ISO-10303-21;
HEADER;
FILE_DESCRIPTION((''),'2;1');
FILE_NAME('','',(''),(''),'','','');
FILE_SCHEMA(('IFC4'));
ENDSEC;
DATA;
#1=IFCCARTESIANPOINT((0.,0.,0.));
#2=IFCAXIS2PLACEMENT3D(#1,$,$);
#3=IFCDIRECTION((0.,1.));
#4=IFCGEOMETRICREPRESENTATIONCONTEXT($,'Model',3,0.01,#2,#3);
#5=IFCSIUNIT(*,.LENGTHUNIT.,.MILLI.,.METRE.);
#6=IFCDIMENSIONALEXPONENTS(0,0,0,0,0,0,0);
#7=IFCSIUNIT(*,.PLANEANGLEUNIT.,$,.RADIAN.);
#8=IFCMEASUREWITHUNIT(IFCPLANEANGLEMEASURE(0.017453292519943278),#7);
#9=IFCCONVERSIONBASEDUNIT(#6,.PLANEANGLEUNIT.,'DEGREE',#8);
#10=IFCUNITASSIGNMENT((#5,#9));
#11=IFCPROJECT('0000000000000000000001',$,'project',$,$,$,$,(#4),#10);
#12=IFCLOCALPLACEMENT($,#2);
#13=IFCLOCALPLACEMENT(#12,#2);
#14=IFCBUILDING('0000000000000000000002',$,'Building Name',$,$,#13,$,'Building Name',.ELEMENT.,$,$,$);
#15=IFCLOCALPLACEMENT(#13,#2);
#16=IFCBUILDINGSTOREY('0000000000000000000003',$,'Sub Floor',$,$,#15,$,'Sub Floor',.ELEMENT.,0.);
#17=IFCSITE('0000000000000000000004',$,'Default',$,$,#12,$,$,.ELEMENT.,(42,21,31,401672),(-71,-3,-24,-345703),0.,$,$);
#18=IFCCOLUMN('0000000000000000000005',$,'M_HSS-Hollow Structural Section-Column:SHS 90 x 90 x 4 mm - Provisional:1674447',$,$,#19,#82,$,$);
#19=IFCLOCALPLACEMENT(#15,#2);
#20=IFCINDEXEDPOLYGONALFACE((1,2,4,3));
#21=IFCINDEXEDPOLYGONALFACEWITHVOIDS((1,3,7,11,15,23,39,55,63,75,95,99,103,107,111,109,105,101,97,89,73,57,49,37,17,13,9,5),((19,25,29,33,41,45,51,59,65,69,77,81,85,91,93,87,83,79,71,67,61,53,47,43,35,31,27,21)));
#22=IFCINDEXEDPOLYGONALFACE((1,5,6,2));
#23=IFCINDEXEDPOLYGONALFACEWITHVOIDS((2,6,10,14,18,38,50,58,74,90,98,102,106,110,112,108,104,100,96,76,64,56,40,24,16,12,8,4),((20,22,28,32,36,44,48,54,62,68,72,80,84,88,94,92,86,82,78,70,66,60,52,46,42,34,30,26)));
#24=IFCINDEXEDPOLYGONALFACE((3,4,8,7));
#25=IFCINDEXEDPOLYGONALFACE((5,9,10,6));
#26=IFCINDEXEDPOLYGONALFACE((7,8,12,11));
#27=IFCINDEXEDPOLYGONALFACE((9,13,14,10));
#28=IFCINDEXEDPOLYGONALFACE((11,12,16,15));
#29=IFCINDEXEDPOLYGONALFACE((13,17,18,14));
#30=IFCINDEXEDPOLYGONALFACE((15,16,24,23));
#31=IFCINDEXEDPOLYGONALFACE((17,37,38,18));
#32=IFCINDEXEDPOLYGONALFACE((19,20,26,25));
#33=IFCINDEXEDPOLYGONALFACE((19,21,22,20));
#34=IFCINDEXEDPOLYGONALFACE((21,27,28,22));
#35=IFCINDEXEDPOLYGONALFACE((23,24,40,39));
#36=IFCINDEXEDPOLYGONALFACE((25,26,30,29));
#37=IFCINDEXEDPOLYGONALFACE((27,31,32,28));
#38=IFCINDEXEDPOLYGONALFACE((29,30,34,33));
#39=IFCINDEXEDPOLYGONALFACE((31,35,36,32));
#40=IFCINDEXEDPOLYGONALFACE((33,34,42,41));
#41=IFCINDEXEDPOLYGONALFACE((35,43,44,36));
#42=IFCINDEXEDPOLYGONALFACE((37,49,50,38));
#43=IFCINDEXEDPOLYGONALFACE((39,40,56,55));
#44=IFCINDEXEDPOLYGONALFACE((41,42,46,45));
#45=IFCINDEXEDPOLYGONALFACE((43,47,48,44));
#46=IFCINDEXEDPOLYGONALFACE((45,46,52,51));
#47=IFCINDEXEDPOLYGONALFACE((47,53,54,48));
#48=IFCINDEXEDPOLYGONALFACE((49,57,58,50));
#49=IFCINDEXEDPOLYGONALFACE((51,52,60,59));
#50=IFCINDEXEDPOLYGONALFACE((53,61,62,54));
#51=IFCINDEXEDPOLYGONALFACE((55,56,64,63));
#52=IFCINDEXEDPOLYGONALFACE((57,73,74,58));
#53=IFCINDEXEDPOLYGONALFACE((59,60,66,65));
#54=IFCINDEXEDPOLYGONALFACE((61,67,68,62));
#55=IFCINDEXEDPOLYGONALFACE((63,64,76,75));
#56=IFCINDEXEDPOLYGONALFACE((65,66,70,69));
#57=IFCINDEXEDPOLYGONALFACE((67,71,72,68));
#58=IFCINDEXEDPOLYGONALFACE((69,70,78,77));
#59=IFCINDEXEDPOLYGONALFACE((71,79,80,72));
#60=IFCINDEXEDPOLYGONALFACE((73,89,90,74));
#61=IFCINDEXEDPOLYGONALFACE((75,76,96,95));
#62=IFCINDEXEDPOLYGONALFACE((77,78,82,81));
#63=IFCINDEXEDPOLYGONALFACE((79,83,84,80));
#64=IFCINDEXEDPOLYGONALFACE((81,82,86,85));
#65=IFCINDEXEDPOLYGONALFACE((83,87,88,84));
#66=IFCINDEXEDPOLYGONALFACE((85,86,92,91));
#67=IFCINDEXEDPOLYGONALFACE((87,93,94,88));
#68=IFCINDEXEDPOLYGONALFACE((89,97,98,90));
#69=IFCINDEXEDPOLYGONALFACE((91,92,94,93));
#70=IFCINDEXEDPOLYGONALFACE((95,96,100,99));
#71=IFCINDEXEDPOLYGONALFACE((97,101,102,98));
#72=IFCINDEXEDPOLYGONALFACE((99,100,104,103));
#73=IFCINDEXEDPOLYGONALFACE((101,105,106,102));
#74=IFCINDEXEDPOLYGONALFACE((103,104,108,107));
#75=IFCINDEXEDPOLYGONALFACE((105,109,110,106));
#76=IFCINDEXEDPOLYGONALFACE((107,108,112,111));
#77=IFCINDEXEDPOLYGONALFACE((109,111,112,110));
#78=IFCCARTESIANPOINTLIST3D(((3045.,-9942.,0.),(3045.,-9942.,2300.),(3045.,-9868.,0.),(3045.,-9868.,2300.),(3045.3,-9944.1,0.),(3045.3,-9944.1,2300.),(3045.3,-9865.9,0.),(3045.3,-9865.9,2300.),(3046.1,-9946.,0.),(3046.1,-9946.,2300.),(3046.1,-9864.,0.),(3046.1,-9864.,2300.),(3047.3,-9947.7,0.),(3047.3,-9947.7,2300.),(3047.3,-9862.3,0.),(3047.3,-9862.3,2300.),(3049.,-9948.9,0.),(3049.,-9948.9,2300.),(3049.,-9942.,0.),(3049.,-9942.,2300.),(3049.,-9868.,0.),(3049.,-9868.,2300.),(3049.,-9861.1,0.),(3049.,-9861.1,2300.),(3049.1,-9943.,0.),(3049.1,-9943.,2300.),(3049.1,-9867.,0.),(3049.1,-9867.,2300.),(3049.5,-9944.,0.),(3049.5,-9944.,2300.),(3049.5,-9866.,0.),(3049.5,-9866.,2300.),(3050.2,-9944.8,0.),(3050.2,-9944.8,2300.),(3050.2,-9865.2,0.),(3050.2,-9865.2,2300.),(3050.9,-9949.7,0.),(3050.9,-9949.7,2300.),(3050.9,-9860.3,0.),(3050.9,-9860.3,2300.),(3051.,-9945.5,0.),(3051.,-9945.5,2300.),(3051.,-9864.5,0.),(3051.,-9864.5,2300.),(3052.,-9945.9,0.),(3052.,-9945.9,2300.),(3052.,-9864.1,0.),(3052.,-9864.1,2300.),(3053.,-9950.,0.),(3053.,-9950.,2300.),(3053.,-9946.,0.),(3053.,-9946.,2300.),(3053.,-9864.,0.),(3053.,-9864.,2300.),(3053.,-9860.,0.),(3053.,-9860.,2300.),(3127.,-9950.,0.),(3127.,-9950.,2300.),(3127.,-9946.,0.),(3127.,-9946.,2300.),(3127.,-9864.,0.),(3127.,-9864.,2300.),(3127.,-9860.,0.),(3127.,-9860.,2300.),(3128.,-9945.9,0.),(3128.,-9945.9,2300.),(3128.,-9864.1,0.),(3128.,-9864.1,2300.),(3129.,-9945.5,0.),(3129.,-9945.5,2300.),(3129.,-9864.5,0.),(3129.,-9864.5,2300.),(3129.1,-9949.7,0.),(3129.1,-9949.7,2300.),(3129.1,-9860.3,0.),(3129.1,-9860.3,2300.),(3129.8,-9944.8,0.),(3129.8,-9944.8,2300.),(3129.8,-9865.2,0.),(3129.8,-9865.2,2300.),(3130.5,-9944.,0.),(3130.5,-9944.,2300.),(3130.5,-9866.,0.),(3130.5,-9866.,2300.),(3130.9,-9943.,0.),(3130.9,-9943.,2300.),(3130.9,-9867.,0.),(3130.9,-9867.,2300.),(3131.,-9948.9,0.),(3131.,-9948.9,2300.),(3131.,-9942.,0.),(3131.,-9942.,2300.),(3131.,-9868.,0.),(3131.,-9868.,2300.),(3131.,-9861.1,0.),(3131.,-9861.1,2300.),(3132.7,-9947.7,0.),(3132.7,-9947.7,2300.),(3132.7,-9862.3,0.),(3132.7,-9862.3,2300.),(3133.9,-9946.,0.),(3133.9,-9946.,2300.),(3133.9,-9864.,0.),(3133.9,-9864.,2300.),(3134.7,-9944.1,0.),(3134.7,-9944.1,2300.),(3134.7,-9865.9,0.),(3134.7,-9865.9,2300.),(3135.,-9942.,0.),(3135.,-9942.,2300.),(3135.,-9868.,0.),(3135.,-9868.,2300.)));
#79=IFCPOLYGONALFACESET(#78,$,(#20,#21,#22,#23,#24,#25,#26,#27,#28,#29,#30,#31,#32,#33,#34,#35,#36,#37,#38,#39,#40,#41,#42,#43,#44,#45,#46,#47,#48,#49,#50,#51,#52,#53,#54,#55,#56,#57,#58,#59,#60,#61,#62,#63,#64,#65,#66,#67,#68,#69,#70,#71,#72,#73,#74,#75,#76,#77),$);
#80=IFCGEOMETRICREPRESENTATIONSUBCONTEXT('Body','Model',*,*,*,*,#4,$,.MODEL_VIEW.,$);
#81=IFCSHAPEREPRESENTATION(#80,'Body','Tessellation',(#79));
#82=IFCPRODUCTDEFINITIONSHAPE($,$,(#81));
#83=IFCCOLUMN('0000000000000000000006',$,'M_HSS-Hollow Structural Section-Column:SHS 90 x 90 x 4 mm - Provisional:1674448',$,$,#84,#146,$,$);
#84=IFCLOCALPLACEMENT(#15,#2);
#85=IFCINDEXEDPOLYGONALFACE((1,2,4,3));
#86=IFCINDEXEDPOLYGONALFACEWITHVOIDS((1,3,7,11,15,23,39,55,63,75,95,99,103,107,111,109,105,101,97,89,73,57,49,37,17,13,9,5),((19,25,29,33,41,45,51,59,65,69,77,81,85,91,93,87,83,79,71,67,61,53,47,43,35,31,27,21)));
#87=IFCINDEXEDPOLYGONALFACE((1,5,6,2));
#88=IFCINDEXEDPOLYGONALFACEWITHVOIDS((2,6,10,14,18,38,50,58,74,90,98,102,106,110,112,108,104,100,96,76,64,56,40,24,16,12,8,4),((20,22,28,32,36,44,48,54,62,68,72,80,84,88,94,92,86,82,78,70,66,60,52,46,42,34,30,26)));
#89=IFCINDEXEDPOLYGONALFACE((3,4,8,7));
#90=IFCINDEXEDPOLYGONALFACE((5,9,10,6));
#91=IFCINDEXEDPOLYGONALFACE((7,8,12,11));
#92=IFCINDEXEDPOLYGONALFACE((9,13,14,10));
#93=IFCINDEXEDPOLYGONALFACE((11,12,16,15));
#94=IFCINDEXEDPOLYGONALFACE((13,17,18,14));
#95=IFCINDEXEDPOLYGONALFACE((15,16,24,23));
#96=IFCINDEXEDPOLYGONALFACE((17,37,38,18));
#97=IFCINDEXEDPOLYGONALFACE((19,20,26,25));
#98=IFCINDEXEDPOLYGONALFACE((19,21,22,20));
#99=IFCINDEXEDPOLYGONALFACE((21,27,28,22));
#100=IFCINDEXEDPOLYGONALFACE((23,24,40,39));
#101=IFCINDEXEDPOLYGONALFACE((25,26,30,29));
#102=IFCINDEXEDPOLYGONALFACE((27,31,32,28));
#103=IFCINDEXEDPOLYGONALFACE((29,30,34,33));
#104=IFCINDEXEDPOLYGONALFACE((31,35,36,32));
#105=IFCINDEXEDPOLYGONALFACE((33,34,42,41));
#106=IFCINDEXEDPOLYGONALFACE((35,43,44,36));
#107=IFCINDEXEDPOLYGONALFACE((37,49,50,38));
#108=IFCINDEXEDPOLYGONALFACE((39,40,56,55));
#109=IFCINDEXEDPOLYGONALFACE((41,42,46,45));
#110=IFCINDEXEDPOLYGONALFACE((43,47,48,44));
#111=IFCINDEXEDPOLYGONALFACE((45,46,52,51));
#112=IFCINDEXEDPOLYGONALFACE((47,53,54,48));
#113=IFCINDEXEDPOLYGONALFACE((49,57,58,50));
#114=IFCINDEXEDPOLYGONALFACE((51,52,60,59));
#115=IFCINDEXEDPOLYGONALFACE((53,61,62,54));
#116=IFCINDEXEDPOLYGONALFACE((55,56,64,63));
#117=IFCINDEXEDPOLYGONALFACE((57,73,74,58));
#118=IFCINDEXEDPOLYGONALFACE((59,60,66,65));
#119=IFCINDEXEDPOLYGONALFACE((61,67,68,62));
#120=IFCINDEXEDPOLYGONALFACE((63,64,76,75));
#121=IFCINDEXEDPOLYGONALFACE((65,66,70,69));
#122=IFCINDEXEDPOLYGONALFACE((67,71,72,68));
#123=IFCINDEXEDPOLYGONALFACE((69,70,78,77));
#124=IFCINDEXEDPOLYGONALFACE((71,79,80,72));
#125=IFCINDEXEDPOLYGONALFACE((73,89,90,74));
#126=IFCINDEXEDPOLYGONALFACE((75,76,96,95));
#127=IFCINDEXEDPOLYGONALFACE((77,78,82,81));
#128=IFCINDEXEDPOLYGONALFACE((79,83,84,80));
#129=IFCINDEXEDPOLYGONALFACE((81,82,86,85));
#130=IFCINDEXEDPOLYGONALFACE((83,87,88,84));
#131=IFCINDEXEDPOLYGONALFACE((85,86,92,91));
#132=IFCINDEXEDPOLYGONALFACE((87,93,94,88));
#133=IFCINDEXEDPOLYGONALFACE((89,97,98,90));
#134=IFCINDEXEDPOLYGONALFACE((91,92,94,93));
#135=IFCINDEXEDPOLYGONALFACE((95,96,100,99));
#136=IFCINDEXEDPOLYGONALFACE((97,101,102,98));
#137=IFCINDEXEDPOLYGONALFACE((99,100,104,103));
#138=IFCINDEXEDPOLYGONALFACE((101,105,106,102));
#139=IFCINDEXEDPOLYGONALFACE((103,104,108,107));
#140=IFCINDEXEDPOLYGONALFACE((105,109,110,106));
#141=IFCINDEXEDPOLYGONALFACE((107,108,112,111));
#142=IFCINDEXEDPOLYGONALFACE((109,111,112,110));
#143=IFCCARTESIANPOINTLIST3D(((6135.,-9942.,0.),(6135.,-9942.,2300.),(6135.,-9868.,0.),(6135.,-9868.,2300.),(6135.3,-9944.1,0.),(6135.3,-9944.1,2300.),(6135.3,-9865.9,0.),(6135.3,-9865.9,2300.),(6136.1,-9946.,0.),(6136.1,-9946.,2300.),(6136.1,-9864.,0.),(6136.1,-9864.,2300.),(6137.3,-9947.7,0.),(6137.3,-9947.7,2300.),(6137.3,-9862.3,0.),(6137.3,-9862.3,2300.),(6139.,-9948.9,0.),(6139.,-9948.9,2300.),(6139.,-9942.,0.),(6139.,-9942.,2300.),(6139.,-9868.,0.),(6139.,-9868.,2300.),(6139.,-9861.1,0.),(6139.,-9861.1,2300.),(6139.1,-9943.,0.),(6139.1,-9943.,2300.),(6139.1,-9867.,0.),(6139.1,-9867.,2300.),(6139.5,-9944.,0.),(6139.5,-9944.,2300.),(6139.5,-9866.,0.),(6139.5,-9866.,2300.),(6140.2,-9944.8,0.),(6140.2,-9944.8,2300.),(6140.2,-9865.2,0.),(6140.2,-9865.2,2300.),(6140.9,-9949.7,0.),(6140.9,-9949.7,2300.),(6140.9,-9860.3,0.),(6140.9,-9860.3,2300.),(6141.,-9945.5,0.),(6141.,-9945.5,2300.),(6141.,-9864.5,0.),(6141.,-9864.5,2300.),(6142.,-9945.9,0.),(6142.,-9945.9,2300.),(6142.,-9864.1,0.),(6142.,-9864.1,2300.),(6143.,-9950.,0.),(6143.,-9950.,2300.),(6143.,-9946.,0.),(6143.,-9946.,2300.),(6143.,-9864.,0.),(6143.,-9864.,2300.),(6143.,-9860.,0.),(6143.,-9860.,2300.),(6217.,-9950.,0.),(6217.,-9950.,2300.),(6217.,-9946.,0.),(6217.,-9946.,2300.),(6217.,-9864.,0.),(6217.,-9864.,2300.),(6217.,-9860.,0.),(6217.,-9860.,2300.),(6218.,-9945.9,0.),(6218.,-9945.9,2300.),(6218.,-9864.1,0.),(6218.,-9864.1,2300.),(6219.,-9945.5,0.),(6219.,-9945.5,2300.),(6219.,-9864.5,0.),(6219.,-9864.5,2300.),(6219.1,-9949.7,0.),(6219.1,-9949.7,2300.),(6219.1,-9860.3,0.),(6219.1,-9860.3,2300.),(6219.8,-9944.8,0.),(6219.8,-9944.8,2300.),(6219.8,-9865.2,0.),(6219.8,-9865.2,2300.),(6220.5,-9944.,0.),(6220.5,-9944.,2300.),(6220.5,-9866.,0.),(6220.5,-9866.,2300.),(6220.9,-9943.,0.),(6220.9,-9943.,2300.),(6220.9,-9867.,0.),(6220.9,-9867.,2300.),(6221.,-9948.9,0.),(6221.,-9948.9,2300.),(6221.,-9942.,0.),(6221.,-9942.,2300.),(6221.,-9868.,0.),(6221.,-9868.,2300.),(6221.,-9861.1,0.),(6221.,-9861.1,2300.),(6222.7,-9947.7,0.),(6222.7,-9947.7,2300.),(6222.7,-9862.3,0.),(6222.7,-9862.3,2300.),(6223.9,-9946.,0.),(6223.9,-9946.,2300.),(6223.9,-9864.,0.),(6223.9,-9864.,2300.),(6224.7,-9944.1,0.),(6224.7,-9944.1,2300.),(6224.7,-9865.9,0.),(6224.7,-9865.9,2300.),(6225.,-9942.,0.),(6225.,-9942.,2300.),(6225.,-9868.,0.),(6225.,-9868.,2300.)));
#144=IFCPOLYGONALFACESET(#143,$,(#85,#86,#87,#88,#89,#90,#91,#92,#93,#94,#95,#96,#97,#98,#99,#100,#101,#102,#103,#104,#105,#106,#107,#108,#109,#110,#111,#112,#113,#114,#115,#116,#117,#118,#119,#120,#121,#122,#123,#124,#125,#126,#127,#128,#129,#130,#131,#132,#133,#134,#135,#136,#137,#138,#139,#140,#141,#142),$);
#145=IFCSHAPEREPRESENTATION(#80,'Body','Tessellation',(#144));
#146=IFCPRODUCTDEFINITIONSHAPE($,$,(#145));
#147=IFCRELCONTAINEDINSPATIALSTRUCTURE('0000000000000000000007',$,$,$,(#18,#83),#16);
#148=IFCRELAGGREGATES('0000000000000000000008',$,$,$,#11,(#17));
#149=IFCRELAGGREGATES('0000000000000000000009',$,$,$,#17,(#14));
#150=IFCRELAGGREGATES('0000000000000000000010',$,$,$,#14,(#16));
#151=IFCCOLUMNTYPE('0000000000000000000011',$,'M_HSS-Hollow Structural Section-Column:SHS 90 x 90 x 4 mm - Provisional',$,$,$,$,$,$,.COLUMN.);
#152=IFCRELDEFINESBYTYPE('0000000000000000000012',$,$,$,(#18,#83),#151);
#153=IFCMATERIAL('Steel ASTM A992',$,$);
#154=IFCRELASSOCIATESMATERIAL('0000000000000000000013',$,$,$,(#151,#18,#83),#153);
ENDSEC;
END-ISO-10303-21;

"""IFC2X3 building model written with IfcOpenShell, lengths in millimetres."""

from ifc_helpers import new_model, entity, si_unit, converted_unit, direction, frame, frame_2d, origin, place, context, subcontext, project, spatial, polyline, circle_curve, parameter, trimmed, segment, composite_curve, outline, extrude, source, transform, mapped, material, type_object, type_shapes, element, save


model = new_model("IFC2X3")

# Units and contexts
model_context = context("Model", 3, precision=0.01, world=origin(), true_north=direction((0.0, 1.0)))
body_context = subcontext(model_context, "Body", "Model", "MODEL_VIEW")
ifc_project = project(units=[si_unit("LENGTHUNIT", "METRE", prefix="MILLI"), converted_unit("PLANEANGLEUNIT", "DEGREE", entity("IfcPlaneAngleMeasure", 0.017453292519943278), si_unit("PLANEANGLEUNIT", "RADIAN"), dimensions=[0, 0, 0, 0, 0, 0, 0])], contexts=[model_context])

# Site, building, storey
site_placement = place(None, origin())
site = spatial("IfcSite", under=ifc_project, at=site_placement, Name="Default", CompositionType="ELEMENT", RefLatitude=(42, 21, 31, 401672), RefLongitude=(-71, -3, -24, -345703), RefElevation=0.0)
building_placement = place(site_placement, origin())
building = spatial("IfcBuilding", under=site, at=building_placement, Name="Building Name", LongName="Building Name", CompositionType="ELEMENT")
storey_placement = place(building_placement, origin())
storey = spatial("IfcBuildingStorey", under=building, at=storey_placement, Name="Sub Floor", LongName="Sub Floor", CompositionType="ELEMENT", Elevation=0.0)

# Columns
ifc_material_1 = material(Name="Steel ASTM A992")
column_type = type_object("IfcColumnType", Name="M_HSS-Hollow Structural Section-Column:SHS 90 x 90 x 4 mm - Provisional", PredefinedType="COLUMN", material=ifc_material_1)
shared_shape_1 = source(origin(), body_context, "Body", "SweptSolid", [
    extrude(outline(composite_curve([segment(polyline([(-37.0, -45.0), (37.0, -45.0)]), True, "CONTINUOUS"), segment(trimmed(circle_curve(frame_2d((37.0, -37.0), x_axis=(-1.0, 0.0)), 8.0), [parameter(90.0)], [parameter(180.0)], True, "PARAMETER"), True, "CONTINUOUS"), segment(polyline([(45.0, -37.0), (45.0, 37.0)]), True, "CONTINUOUS"), segment(trimmed(circle_curve(frame_2d((37.0, 37.0), x_axis=(-1.0, 0.0)), 8.0), [parameter(180.0)], [parameter(270.0)], True, "PARAMETER"), True, "CONTINUOUS"), segment(polyline([(37.0, 45.0), (-37.0, 45.0)]), True, "CONTINUOUS"), segment(trimmed(circle_curve(frame_2d((-37.0, 37.0), x_axis=(-1.0, 0.0)), 8.0), [parameter(270.0)], [parameter(360.0)], True, "PARAMETER"), True, "CONTINUOUS"), segment(polyline([(-45.0, 37.0), (-45.0, -37.0)]), True, "CONTINUOUS"), segment(trimmed(circle_curve(frame_2d((-37.0, -37.0), x_axis=(-1.0, 0.0)), 8.0), [parameter(360.0)], [parameter(90.0)], True, "PARAMETER"), True, "CONTINUOUS")], self_intersect=False), holes=[composite_curve([segment(trimmed(circle_curve(frame_2d((-37.0, -37.0), x_axis=(-1.0, 0.0)), 4.0), [parameter(0.0)], [parameter(90.0)], True, "PARAMETER"), False, "CONTINUOUS"), segment(polyline([(-41.0, -37.0), (-41.0, 37.0)]), True, "CONTINUOUS"), segment(trimmed(circle_curve(frame_2d((-37.0, 37.0), x_axis=(-1.0, 0.0)), 4.0), [parameter(270.0)], [parameter(0.0)], True, "PARAMETER"), False, "CONTINUOUS"), segment(polyline([(-37.0, 41.0), (37.0, 41.0)]), True, "CONTINUOUS"), segment(trimmed(circle_curve(frame_2d((37.0, 37.0), x_axis=(-1.0, 0.0)), 4.0), [parameter(180.0)], [parameter(270.0)], True, "PARAMETER"), False, "CONTINUOUS"), segment(polyline([(41.0, 37.0), (41.0, -37.0)]), True, "CONTINUOUS"), segment(trimmed(circle_curve(frame_2d((37.0, -37.0), x_axis=(-1.0, 0.0)), 4.0), [parameter(90.0)], [parameter(180.0)], True, "PARAMETER"), False, "CONTINUOUS"), segment(polyline([(37.0, -41.0), (-37.0, -41.0)]), True, "CONTINUOUS")], self_intersect=False)]), frame((0.0, 0.0, 0.0), z_axis=(0.0, 0.0, 1.0), x_axis=(-1.0, 0.0, 0.0)), (0.0, 0.0, 1.0), 2300.0),
])
type_shapes(column_type, [shared_shape_1])
for number, where, name in (
    (1, (3090.0, -9905.0, 0.0), "M_HSS-Hollow Structural Section-Column:SHS 90 x 90 x 4 mm - Provisional:1674447"),
    (2, (6180.0, -9905.0, 0.0), "M_HSS-Hollow Structural Section-Column:SHS 90 x 90 x 4 mm - Provisional:1674448"),
):
    element("IfcColumn", number, at=place(storey_placement, frame(where)), inside=storey, type_object=column_type, material=ifc_material_1, Name=name, context=body_context, shape_type="MappedRepresentation", body=[
        mapped(shared_shape_1, transform((0.0, 0.0, 0.0), scale=1.0)),
    ])

save(model, "model.ifc")
